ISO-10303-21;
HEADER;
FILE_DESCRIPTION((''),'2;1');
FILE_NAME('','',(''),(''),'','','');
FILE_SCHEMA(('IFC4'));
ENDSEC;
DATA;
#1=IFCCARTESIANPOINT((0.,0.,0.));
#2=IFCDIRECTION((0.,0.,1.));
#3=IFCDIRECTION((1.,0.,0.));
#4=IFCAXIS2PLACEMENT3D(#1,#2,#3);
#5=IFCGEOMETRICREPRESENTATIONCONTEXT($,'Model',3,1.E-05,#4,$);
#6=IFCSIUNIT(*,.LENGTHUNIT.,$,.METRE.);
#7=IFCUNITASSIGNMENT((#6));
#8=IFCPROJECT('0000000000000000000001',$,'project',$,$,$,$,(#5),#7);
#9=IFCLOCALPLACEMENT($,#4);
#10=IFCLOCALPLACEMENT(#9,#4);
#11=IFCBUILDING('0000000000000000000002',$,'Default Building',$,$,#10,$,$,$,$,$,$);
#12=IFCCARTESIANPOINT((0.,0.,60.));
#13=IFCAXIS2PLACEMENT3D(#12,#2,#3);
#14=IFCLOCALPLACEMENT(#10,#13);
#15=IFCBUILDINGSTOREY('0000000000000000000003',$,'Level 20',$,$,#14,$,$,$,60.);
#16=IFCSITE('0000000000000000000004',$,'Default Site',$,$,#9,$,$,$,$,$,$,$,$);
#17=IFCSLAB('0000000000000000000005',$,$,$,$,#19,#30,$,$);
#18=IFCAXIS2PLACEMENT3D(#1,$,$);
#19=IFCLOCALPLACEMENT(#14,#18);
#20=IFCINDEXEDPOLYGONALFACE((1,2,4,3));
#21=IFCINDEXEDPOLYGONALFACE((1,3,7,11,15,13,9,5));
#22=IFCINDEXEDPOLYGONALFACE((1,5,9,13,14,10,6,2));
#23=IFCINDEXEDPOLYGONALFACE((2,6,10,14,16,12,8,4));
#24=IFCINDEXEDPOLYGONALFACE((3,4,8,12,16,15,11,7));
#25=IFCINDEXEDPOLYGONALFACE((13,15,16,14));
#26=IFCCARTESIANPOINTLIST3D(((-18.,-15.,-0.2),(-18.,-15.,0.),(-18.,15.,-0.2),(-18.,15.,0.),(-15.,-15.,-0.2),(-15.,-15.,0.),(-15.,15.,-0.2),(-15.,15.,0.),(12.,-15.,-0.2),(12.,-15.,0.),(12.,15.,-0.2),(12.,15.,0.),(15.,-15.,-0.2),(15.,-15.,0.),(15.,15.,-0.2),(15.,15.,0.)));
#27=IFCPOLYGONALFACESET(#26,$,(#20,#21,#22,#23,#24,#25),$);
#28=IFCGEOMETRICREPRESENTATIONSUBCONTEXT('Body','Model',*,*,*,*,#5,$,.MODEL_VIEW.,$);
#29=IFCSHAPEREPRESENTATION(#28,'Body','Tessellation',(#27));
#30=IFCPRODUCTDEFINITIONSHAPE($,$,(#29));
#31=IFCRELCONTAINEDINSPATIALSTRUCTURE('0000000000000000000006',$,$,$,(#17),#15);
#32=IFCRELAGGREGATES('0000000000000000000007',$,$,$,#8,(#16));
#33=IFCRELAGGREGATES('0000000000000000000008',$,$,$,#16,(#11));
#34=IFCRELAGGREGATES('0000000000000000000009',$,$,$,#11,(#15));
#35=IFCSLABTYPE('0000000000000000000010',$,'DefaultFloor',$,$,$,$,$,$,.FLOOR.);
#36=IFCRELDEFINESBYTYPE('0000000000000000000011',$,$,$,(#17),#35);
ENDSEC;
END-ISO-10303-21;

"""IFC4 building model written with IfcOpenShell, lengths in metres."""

from ifc_helpers import new_model, si_unit, frame, origin_with_axes, place, context, subcontext, project, spatial, polyline, outline, extrude, type_object, element, save


model = new_model("IFC4")

# Units and contexts
model_context = context("Model", 3, precision=1e-05, world=origin_with_axes())
body_context = subcontext(model_context, "Body", "Model", "MODEL_VIEW")
ifc_project = project(units=[si_unit("LENGTHUNIT", "METRE")], contexts=[model_context])

# Site, building, storey
site_placement = place(None, origin_with_axes())
site = spatial("IfcSite", under=ifc_project, at=site_placement, Name="Default Site")
building_placement = place(site_placement, origin_with_axes())
building = spatial("IfcBuilding", under=site, at=building_placement, Name="Default Building")
storey_placement = place(building_placement, frame((0.0, 0.0, 60.0), z_axis=(0.0, 0.0, 1.0), x_axis=(1.0, 0.0, 0.0)))
storey = spatial("IfcBuildingStorey", under=building, at=storey_placement, Name="Level 20", Elevation=60.0)

# Slab
slab_type = type_object("IfcSlabType", Name="DefaultFloor", PredefinedType="FLOOR")
slab_placement = place(storey_placement, frame((0.0, 0.0, -60.0), z_axis=(0.0, 0.0, 1.0), x_axis=(1.0, 0.0, 0.0)))
element("IfcSlab", 1, at=slab_placement, inside=storey, type_object=slab_type, context=body_context, shape_type="SweptSolid", body=[
    extrude(outline(polyline([(-18.0, 15.0), (-15.0, 15.0), (12.0, 15.0), (15.0, 15.0), (15.0, -15.0), (12.0, -15.0), (-15.0, -15.0), (-18.0, -15.0), (-18.0, 15.0)])), frame((0.0, 0.0, 60.0), z_axis=(0.0, 0.0, 1.0), x_axis=(1.0, 0.0, 0.0)), (0.0, 0.0, -1.0), 0.2),
])

save(model, "model.ifc")
